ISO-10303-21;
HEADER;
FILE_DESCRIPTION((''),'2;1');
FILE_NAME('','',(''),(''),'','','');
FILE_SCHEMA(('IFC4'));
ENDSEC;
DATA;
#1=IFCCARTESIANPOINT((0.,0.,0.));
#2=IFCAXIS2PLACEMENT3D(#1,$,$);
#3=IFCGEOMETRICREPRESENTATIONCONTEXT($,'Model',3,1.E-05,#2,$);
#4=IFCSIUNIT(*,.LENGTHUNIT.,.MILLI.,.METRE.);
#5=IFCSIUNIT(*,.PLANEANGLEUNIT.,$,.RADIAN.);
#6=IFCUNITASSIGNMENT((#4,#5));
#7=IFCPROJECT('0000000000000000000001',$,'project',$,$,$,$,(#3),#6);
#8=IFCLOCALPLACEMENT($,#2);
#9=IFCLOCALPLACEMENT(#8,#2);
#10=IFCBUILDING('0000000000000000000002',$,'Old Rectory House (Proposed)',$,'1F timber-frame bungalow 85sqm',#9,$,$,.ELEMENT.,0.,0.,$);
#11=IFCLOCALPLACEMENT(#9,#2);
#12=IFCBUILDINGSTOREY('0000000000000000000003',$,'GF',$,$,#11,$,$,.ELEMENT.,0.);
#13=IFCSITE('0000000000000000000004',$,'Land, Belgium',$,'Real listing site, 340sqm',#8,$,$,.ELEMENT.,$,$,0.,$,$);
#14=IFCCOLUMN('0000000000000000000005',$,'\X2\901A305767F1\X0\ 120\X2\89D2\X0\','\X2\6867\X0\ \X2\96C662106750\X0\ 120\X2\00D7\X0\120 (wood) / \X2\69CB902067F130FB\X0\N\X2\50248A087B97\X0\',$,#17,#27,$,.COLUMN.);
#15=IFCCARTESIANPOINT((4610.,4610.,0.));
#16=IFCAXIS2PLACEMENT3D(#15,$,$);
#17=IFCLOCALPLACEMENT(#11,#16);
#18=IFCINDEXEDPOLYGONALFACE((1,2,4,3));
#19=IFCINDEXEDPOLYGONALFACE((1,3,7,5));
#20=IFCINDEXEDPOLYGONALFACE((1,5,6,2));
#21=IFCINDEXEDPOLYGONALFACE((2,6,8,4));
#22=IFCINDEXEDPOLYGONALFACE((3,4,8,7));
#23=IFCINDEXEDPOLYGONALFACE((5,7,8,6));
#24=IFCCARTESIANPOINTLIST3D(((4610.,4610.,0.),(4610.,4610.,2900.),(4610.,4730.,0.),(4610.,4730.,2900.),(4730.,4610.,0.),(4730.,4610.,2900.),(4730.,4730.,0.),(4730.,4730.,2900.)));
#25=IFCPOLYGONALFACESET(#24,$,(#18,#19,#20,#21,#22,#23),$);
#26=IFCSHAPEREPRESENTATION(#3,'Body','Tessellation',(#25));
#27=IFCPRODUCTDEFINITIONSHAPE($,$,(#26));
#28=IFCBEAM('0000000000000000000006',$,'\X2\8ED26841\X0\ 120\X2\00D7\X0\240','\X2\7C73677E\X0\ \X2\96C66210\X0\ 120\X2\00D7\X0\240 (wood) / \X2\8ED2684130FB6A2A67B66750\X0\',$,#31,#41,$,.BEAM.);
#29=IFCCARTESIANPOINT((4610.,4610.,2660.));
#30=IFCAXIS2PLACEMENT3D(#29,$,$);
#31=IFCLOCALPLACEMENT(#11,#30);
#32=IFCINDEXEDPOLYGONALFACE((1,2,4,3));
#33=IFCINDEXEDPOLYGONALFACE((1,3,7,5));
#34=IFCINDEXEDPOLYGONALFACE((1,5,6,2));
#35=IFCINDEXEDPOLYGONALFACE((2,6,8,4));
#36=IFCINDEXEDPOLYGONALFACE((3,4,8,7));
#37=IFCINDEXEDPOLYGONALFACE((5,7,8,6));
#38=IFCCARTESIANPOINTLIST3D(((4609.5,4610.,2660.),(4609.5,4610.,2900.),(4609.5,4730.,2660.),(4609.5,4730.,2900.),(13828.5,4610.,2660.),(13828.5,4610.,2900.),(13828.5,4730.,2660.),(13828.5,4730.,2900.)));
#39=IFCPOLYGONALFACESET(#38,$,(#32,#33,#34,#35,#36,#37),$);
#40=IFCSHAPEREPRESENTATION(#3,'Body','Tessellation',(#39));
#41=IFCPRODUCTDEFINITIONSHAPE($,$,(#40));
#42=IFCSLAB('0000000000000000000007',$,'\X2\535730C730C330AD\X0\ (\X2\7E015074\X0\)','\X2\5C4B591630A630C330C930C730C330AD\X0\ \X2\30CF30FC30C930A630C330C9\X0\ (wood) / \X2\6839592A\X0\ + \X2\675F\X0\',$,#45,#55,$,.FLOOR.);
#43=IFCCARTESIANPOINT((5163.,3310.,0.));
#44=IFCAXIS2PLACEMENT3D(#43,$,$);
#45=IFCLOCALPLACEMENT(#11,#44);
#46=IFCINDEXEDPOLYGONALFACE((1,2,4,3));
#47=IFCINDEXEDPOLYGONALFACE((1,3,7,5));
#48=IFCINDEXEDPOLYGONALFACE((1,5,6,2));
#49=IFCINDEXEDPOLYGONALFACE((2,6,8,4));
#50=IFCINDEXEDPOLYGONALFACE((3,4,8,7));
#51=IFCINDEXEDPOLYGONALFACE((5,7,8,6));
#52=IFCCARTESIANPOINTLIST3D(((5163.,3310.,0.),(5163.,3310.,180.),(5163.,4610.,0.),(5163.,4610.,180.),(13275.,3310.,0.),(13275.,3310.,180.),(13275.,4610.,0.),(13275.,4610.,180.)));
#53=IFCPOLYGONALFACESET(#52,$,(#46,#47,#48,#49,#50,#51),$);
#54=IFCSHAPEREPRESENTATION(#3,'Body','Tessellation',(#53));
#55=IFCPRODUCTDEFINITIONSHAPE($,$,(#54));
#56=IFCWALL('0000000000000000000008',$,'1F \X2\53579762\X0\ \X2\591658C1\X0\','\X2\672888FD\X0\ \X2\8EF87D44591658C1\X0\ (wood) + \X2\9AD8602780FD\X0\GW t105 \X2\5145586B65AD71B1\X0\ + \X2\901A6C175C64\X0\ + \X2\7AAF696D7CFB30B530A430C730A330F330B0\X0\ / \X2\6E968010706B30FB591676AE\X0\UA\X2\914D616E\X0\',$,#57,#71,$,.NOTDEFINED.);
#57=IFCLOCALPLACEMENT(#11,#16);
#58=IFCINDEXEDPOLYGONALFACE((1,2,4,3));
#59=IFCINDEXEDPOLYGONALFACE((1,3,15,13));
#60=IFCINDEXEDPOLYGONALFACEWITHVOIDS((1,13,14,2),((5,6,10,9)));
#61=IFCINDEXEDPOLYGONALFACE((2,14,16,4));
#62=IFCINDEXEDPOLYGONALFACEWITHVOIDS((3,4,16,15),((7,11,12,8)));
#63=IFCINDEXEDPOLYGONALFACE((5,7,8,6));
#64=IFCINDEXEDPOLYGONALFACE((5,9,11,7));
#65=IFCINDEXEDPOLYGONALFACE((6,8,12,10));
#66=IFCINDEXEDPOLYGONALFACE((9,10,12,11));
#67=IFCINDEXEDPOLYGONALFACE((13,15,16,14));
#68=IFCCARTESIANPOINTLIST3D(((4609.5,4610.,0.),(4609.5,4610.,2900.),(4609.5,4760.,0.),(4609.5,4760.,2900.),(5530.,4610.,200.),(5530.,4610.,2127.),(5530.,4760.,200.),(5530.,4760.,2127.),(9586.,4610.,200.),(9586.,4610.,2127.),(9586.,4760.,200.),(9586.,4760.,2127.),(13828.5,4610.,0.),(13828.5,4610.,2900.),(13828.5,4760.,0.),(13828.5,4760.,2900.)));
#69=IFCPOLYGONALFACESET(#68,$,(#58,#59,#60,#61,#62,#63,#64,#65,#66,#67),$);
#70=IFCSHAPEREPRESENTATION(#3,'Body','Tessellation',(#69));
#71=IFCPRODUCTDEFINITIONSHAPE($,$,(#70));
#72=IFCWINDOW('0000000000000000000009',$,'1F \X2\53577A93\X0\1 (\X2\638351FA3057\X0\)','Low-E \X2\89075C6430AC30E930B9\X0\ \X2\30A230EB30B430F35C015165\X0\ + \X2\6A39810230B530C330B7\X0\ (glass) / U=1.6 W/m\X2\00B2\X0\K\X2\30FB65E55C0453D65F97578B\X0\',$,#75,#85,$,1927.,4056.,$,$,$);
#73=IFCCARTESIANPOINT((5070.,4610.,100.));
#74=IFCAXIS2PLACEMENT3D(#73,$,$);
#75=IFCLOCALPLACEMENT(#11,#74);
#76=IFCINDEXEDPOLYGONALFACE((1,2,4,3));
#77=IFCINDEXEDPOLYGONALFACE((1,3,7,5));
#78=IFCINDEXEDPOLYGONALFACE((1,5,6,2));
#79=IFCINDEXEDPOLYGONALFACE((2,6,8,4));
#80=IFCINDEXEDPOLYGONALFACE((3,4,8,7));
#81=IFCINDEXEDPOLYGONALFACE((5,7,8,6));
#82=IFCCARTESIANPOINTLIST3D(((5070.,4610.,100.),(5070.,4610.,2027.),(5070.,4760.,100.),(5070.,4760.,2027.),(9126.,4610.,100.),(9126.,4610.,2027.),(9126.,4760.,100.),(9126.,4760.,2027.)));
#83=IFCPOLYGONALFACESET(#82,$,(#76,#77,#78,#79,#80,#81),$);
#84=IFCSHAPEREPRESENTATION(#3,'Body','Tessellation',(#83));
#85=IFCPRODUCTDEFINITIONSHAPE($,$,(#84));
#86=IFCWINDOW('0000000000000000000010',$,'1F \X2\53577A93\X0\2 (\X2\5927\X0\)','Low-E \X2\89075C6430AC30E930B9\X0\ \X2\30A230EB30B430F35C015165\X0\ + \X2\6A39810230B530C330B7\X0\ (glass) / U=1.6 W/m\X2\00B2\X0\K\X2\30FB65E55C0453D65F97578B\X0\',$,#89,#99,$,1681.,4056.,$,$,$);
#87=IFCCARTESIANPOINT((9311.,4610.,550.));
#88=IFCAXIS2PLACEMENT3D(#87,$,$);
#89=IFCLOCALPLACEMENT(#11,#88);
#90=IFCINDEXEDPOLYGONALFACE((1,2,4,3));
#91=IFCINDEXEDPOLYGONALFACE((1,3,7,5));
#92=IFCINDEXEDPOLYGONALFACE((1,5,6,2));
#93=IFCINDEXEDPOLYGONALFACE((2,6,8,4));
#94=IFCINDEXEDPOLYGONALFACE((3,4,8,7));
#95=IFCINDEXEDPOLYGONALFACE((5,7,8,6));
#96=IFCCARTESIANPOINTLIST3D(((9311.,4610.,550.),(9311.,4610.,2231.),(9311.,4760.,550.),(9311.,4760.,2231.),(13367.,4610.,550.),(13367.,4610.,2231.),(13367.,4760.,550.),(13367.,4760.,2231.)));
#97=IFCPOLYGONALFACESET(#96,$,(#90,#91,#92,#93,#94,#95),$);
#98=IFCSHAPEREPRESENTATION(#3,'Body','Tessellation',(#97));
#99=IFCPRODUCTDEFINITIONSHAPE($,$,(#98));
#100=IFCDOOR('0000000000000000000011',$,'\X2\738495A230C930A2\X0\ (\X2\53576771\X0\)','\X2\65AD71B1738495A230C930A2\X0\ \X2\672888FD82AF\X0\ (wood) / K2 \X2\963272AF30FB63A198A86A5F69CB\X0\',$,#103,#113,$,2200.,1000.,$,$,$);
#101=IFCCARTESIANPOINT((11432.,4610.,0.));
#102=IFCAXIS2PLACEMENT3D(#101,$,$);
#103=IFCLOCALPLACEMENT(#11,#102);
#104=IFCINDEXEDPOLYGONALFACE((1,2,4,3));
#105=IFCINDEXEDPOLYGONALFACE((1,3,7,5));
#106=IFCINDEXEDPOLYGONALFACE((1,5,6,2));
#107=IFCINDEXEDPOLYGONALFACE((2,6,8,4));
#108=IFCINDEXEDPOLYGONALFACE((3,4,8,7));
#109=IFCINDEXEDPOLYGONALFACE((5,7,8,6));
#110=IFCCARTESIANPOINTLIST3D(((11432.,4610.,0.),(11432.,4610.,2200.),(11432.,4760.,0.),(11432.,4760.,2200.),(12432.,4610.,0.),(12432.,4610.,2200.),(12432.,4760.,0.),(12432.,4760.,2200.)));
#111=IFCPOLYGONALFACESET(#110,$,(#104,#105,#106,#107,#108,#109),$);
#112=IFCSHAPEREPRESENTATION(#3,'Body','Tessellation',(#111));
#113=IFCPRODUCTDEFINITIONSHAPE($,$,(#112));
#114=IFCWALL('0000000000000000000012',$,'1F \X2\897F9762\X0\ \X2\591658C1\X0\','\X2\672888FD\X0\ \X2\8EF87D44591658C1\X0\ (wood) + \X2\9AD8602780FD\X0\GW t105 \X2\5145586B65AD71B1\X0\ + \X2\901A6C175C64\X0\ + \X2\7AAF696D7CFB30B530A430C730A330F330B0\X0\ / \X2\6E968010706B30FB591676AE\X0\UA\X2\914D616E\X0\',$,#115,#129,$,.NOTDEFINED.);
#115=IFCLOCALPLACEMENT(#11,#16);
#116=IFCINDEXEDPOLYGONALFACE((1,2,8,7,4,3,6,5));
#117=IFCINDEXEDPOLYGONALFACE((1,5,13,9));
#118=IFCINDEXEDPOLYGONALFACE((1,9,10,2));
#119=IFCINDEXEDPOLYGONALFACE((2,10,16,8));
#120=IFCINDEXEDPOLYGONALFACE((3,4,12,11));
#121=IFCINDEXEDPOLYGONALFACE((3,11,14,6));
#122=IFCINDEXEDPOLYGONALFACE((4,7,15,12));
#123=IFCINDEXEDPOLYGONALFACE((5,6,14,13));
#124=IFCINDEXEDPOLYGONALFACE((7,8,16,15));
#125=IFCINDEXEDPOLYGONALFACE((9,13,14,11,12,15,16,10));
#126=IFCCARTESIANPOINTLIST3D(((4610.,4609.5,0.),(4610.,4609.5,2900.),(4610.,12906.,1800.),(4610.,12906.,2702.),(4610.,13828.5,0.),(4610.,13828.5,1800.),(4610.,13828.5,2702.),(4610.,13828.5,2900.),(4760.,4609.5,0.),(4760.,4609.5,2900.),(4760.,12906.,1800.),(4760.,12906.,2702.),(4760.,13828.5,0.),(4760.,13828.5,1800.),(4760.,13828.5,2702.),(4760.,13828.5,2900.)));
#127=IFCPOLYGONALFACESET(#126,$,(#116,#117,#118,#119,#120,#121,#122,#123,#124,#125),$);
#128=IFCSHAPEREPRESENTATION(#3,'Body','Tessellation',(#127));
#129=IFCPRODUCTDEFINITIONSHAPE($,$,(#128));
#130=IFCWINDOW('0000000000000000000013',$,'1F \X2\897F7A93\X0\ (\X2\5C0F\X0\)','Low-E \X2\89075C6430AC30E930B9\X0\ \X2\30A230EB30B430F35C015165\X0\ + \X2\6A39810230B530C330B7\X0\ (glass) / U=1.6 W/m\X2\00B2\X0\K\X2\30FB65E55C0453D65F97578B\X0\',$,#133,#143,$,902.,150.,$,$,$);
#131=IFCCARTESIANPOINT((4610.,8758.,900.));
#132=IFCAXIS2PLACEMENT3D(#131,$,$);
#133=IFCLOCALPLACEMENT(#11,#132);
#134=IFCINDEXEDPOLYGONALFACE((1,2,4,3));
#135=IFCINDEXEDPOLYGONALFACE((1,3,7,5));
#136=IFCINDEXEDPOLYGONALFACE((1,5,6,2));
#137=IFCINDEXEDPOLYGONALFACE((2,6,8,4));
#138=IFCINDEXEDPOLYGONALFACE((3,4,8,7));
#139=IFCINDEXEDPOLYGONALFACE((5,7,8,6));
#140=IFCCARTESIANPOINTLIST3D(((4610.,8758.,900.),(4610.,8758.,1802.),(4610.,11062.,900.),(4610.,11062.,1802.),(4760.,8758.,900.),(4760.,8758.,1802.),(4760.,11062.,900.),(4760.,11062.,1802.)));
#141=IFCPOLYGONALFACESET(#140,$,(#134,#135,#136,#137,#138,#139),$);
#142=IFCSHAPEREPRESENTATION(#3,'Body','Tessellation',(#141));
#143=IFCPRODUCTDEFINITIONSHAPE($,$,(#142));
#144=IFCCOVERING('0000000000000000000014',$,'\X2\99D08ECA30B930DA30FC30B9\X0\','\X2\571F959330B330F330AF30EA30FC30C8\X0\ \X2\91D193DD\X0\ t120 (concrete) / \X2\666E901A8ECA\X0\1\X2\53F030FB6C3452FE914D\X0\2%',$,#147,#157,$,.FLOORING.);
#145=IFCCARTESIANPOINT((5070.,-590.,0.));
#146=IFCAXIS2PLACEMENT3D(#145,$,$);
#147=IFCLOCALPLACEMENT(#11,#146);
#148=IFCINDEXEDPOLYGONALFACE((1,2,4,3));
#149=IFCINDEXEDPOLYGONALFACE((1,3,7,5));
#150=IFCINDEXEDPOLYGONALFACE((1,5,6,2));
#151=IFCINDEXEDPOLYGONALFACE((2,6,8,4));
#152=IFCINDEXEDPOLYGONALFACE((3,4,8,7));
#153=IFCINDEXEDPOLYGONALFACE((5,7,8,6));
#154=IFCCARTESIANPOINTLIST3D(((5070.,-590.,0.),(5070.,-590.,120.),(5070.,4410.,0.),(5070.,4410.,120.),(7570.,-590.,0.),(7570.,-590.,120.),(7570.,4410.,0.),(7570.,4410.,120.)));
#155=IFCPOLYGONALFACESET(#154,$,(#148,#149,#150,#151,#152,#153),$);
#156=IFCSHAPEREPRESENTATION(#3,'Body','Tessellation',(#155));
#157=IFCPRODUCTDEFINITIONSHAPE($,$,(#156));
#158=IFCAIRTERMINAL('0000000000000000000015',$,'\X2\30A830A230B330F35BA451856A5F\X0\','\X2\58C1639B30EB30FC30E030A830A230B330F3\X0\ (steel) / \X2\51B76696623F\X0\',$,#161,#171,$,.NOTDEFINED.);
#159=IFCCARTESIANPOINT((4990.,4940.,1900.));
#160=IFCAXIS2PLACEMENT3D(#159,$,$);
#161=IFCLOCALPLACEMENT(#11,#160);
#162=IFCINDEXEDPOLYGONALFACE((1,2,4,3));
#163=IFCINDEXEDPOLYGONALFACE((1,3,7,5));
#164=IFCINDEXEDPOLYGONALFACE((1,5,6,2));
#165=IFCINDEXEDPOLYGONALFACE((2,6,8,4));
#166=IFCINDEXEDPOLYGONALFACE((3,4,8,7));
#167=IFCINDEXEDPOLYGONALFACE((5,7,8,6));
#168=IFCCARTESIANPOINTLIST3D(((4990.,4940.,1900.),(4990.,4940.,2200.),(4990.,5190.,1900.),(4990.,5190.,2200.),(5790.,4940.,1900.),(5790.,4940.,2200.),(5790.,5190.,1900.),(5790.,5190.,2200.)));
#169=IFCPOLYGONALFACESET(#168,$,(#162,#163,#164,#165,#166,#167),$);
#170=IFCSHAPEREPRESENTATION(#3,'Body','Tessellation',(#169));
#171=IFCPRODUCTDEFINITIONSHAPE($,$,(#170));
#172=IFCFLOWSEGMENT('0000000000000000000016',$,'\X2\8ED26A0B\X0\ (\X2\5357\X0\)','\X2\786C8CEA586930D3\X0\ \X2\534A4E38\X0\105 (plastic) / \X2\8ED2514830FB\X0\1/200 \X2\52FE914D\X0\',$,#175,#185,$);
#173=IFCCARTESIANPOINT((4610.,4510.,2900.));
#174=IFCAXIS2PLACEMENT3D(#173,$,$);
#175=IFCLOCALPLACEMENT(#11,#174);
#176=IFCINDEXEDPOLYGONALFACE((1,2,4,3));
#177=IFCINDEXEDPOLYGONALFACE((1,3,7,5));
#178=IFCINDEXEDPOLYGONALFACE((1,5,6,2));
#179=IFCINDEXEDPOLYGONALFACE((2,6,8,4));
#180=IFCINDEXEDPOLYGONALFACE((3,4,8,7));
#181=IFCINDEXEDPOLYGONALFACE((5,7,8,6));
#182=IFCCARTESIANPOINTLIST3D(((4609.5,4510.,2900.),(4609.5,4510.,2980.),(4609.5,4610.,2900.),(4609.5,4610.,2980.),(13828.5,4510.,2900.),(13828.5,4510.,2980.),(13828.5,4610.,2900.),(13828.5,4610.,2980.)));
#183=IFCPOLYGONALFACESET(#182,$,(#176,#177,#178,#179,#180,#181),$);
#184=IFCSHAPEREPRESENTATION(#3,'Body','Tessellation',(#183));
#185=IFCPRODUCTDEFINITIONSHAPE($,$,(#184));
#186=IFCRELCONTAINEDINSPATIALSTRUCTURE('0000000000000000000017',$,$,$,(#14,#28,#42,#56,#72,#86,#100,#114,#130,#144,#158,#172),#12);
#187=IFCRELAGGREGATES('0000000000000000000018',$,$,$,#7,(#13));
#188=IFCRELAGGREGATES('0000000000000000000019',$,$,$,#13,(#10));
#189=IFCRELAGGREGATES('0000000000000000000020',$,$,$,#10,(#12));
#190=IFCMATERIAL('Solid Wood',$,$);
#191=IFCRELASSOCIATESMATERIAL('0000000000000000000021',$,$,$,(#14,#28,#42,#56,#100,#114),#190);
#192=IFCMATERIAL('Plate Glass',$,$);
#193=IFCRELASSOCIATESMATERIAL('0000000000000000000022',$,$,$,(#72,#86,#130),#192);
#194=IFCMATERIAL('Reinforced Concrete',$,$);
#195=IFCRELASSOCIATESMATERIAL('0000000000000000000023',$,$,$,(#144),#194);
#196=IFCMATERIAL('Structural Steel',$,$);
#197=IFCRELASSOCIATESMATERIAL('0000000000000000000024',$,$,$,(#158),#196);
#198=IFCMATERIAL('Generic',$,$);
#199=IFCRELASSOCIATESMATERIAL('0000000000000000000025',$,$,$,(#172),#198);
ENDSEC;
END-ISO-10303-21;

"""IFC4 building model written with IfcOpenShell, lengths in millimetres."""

from ifc_helpers import new_model, si_unit, frame, frame_2d, origin, place, context, project, spatial, rectangle, extrude, material, element, fill, save


model = new_model("IFC4")

# Units and contexts
model_context = context("Model", 3, precision=1e-05, world=origin())
ifc_project = project(units=[si_unit("LENGTHUNIT", "METRE", prefix="MILLI"), si_unit("PLANEANGLEUNIT", "RADIAN")], contexts=[model_context])

# Site, building, storey
site_placement = place(None, origin())
site = spatial("IfcSite", under=ifc_project, at=site_placement, Name="Land, Belgium", ObjectType="Real listing site, 340sqm", CompositionType="ELEMENT", RefElevation=0.0)
building_placement = place(site_placement, origin())
building = spatial("IfcBuilding", under=site, at=building_placement, Name="Old Rectory House (Proposed)", ObjectType="1F timber-frame bungalow 85sqm", CompositionType="ELEMENT", ElevationOfRefHeight=0.0, ElevationOfTerrain=0.0)
storey_placement = place(building_placement, origin())
storey = spatial("IfcBuildingStorey", under=building, at=storey_placement, Name="GF", CompositionType="ELEMENT", Elevation=0.0)

# Column
ifc_material_1 = material(Name="Solid Wood")
column_1_placement = place(storey_placement, frame((4610.0, 4610.0, 0.0)))
element("IfcColumn", 1, at=column_1_placement, inside=storey, material=ifc_material_1, Name="通し柱 120角", Description="桧 集成材 120×120 (wood) / 構造柱・N値計算", PredefinedType="COLUMN", context=model_context, shape_type="SweptSolid", body=[
    extrude(rectangle(XDim=120.0, YDim=120.0, at=frame_2d((60.0, 60.0))), frame((4610.0, 4610.0, 0.0)), (0.0, 0.0, 1.0), 2900.0),
])

# Beam
beam_1_placement = place(storey_placement, frame((4610.0, 4610.0, 2660.0)))
element("IfcBeam", 2, at=beam_1_placement, inside=storey, material=ifc_material_1, Name="軒桁 120×240", Description="米松 集成 120×240 (wood) / 軒桁・横架材", PredefinedType="BEAM", context=model_context, shape_type="SweptSolid", body=[
    extrude(rectangle(XDim=9219.0, YDim=120.0, at=frame_2d((4609.0, 60.0))), frame((4610.0, 4610.0, 2660.0)), (0.0, 0.0, 1.0), 240.0),
])

# Slab
ifc_material_2 = material(Name="Reinforced Concrete")
slab_1_placement = place(storey_placement, frame((5163.0, 3310.0, 0.0)))
element("IfcSlab", 3, at=slab_1_placement, inside=storey, material=ifc_material_1, Name="南デッキ (縁側)", Description="屋外ウッドデッキ ハードウッド (wood) / 根太 + 束", PredefinedType="FLOOR", context=model_context, shape_type="SweptSolid", body=[
    extrude(rectangle(XDim=8112.0, YDim=1300.0, at=frame_2d((4056.0, 650.0))), frame((5163.0, 3310.0, 0.0)), (0.0, 0.0, 1.0), 180.0),
])

# Wall, openings, windows, door
wall_1_placement = place(storey_placement, frame((4610.0, 4610.0, 0.0)))
wall_1 = element("IfcWall", 4, at=wall_1_placement, inside=storey, material=ifc_material_1, Name="1F 南面 外壁", Description="木製 軸組外壁 (wood) + 高性能GW t105 充填断熱 + 通気層 + 窯業系サイディング / 準耐火・外皮UA配慮", PredefinedType="NOTDEFINED", context=model_context, shape_type="SweptSolid", body=[
    extrude(rectangle(XDim=9219.0, YDim=150.0, at=frame_2d((4609.0, 75.0))), frame((4610.0, 4610.0, 0.0)), (0.0, 0.0, 1.0), 2900.0),
])
opening_1_placement = place(storey_placement, frame((5070.0, 4610.0, 100.0)))
opening_1 = element("IfcOpeningElement", 5, at=opening_1_placement, cuts=wall_1, PredefinedType="NOTDEFINED", context=model_context, shape_type="SweptSolid", body=[
    extrude(rectangle(XDim=4056.0, YDim=150.0, at=frame_2d((2028.0, 75.0))), frame((5070.0, 4610.0, 100.0)), (0.0, 0.0, 1.0), 1927.0),
])
opening_2_placement = place(storey_placement, frame((9311.0, 4610.0, 550.0)))
opening_2 = element("IfcOpeningElement", 6, at=opening_2_placement, cuts=wall_1, PredefinedType="NOTDEFINED", context=model_context, shape_type="SweptSolid", body=[
    extrude(rectangle(XDim=4056.0, YDim=150.0, at=frame_2d((2028.0, 75.0))), frame((9311.0, 4610.0, 550.0)), (0.0, 0.0, 1.0), 1681.0),
])
opening_3_placement = place(storey_placement, frame((11432.0, 4610.0, 0.0)))
opening_3 = element("IfcOpeningElement", 7, at=opening_3_placement, cuts=wall_1, PredefinedType="NOTDEFINED", context=model_context, shape_type="SweptSolid", body=[
    extrude(rectangle(XDim=1000.0, YDim=150.0, at=frame_2d((500.0, 75.0))), frame((11432.0, 4610.0, 0.0)), (0.0, 0.0, 1.0), 2200.0),
])
ifc_material_3 = material(Name="Plate Glass")
window_1_placement = place(storey_placement, frame((5070.0, 4610.0, 100.0)))
window_1 = element("IfcWindow", 8, at=window_1_placement, inside=storey, material=ifc_material_3, Name="1F 南窓1 (掃出し)", Description="Low-E 複層ガラス アルゴン封入 + 樹脂サッシ (glass) / U=1.6 W/m²K・日射取得型", OverallHeight=1927.0, OverallWidth=4056.0, context=model_context, shape_type="SweptSolid", body=[
    extrude(rectangle(XDim=4056.0, YDim=150.0, at=frame_2d((2028.0, 75.0))), frame((5070.0, 4610.0, 100.0)), (0.0, 0.0, 1.0), 1927.0),
])
fill(opening_1, window_1)
window_2_placement = place(storey_placement, frame((9311.0, 4610.0, 550.0)))
window_2 = element("IfcWindow", 9, at=window_2_placement, inside=storey, material=ifc_material_3, Name="1F 南窓2 (大)", Description="Low-E 複層ガラス アルゴン封入 + 樹脂サッシ (glass) / U=1.6 W/m²K・日射取得型", OverallHeight=1681.0, OverallWidth=4056.0, context=model_context, shape_type="SweptSolid", body=[
    extrude(rectangle(XDim=4056.0, YDim=150.0, at=frame_2d((2028.0, 75.0))), frame((9311.0, 4610.0, 550.0)), (0.0, 0.0, 1.0), 1681.0),
])
fill(opening_2, window_2)
door_placement = place(storey_placement, frame((11432.0, 4610.0, 0.0)))
door = element("IfcDoor", 10, at=door_placement, inside=storey, material=ifc_material_1, Name="玄関ドア (南東)", Description="断熱玄関ドア 木製芯 (wood) / K2 防犯・採風機構", OverallHeight=2200.0, OverallWidth=1000.0, context=model_context, shape_type="SweptSolid", body=[
    extrude(rectangle(XDim=1000.0, YDim=150.0, at=frame_2d((500.0, 75.0))), frame((11432.0, 4610.0, 0.0)), (0.0, 0.0, 1.0), 2200.0),
])
fill(opening_3, door)

# Wall, opening, window
wall_2_placement = place(storey_placement, frame((4610.0, 4610.0, 0.0)))
wall_2 = element("IfcWall", 11, at=wall_2_placement, inside=storey, material=ifc_material_1, Name="1F 西面 外壁", Description="木製 軸組外壁 (wood) + 高性能GW t105 充填断熱 + 通気層 + 窯業系サイディング / 準耐火・外皮UA配慮", PredefinedType="NOTDEFINED", context=model_context, shape_type="SweptSolid", body=[
    extrude(rectangle(XDim=150.0, YDim=9219.0, at=frame_2d((75.0, 4609.0))), frame((4610.0, 4610.0, 0.0)), (0.0, 0.0, 1.0), 2900.0),
])
opening_4_placement = place(storey_placement, frame((4610.0, 8758.0, 900.0)))
opening_4 = element("IfcOpeningElement", 12, at=opening_4_placement, cuts=wall_2, PredefinedType="NOTDEFINED", context=model_context, shape_type="SweptSolid", body=[
    extrude(rectangle(XDim=150.0, YDim=2304.0, at=frame_2d((75.0, 1152.0))), frame((4610.0, 8758.0, 900.0)), (0.0, 0.0, 1.0), 902.0),
])
window_3_placement = place(storey_placement, frame((4610.0, 8758.0, 900.0)))
window_3 = element("IfcWindow", 13, at=window_3_placement, inside=storey, material=ifc_material_3, Name="1F 西窓 (小)", Description="Low-E 複層ガラス アルゴン封入 + 樹脂サッシ (glass) / U=1.6 W/m²K・日射取得型", OverallHeight=902.0, OverallWidth=150.0, context=model_context, shape_type="SweptSolid", body=[
    extrude(rectangle(XDim=150.0, YDim=2304.0, at=frame_2d((75.0, 1152.0))), frame((4610.0, 8758.0, 900.0)), (0.0, 0.0, 1.0), 902.0),
])
fill(opening_4, window_3)

# Shared definitions
ifc_material_4 = material(Name="Structural Steel")

# Covering
ifc_material_5 = material(Name="Generic")
covering_1_placement = place(storey_placement, frame((5070.0, -590.0, 0.0)))
element("IfcCovering", 14, at=covering_1_placement, inside=storey, material=ifc_material_2, Name="駐車スペース", Description="土間コンクリート 金鏝 t120 (concrete) / 普通車1台・水勾配2%", PredefinedType="FLOORING", context=model_context, shape_type="SweptSolid", body=[
    extrude(rectangle(XDim=2500.0, YDim=5000.0, at=frame_2d((1250.0, 2500.0))), frame((5070.0, -590.0, 0.0)), (0.0, 0.0, 1.0), 120.0),
])

# Air terminal
air_terminal_placement = place(storey_placement, frame((4990.0, 4940.0, 1900.0)))
element("IfcAirTerminal", 15, at=air_terminal_placement, inside=storey, material=ifc_material_4, Name="エアコン室内機", Description="壁掛ルームエアコン (steel) / 冷暖房", PredefinedType="NOTDEFINED", context=model_context, shape_type="SweptSolid", body=[
    extrude(rectangle(XDim=800.0, YDim=250.0, at=frame_2d((400.0, 125.0))), frame((4990.0, 4940.0, 1900.0)), (0.0, 0.0, 1.0), 300.0),
])

# Flow segment
flow_segment_1_placement = place(storey_placement, frame((4610.0, 4510.0, 2900.0)))
element("IfcFlowSegment", 16, at=flow_segment_1_placement, inside=storey, material=ifc_material_5, Name="軒樋 (南)", Description="硬質塩ビ 半丸105 (plastic) / 軒先・1/200 勾配", context=model_context, shape_type="SweptSolid", body=[
    extrude(rectangle(XDim=9219.0, YDim=100.0, at=frame_2d((4609.0, 50.0))), frame((4610.0, 4510.0, 2900.0)), (0.0, 0.0, 1.0), 80.0),
])

save(model, "model.ifc")
